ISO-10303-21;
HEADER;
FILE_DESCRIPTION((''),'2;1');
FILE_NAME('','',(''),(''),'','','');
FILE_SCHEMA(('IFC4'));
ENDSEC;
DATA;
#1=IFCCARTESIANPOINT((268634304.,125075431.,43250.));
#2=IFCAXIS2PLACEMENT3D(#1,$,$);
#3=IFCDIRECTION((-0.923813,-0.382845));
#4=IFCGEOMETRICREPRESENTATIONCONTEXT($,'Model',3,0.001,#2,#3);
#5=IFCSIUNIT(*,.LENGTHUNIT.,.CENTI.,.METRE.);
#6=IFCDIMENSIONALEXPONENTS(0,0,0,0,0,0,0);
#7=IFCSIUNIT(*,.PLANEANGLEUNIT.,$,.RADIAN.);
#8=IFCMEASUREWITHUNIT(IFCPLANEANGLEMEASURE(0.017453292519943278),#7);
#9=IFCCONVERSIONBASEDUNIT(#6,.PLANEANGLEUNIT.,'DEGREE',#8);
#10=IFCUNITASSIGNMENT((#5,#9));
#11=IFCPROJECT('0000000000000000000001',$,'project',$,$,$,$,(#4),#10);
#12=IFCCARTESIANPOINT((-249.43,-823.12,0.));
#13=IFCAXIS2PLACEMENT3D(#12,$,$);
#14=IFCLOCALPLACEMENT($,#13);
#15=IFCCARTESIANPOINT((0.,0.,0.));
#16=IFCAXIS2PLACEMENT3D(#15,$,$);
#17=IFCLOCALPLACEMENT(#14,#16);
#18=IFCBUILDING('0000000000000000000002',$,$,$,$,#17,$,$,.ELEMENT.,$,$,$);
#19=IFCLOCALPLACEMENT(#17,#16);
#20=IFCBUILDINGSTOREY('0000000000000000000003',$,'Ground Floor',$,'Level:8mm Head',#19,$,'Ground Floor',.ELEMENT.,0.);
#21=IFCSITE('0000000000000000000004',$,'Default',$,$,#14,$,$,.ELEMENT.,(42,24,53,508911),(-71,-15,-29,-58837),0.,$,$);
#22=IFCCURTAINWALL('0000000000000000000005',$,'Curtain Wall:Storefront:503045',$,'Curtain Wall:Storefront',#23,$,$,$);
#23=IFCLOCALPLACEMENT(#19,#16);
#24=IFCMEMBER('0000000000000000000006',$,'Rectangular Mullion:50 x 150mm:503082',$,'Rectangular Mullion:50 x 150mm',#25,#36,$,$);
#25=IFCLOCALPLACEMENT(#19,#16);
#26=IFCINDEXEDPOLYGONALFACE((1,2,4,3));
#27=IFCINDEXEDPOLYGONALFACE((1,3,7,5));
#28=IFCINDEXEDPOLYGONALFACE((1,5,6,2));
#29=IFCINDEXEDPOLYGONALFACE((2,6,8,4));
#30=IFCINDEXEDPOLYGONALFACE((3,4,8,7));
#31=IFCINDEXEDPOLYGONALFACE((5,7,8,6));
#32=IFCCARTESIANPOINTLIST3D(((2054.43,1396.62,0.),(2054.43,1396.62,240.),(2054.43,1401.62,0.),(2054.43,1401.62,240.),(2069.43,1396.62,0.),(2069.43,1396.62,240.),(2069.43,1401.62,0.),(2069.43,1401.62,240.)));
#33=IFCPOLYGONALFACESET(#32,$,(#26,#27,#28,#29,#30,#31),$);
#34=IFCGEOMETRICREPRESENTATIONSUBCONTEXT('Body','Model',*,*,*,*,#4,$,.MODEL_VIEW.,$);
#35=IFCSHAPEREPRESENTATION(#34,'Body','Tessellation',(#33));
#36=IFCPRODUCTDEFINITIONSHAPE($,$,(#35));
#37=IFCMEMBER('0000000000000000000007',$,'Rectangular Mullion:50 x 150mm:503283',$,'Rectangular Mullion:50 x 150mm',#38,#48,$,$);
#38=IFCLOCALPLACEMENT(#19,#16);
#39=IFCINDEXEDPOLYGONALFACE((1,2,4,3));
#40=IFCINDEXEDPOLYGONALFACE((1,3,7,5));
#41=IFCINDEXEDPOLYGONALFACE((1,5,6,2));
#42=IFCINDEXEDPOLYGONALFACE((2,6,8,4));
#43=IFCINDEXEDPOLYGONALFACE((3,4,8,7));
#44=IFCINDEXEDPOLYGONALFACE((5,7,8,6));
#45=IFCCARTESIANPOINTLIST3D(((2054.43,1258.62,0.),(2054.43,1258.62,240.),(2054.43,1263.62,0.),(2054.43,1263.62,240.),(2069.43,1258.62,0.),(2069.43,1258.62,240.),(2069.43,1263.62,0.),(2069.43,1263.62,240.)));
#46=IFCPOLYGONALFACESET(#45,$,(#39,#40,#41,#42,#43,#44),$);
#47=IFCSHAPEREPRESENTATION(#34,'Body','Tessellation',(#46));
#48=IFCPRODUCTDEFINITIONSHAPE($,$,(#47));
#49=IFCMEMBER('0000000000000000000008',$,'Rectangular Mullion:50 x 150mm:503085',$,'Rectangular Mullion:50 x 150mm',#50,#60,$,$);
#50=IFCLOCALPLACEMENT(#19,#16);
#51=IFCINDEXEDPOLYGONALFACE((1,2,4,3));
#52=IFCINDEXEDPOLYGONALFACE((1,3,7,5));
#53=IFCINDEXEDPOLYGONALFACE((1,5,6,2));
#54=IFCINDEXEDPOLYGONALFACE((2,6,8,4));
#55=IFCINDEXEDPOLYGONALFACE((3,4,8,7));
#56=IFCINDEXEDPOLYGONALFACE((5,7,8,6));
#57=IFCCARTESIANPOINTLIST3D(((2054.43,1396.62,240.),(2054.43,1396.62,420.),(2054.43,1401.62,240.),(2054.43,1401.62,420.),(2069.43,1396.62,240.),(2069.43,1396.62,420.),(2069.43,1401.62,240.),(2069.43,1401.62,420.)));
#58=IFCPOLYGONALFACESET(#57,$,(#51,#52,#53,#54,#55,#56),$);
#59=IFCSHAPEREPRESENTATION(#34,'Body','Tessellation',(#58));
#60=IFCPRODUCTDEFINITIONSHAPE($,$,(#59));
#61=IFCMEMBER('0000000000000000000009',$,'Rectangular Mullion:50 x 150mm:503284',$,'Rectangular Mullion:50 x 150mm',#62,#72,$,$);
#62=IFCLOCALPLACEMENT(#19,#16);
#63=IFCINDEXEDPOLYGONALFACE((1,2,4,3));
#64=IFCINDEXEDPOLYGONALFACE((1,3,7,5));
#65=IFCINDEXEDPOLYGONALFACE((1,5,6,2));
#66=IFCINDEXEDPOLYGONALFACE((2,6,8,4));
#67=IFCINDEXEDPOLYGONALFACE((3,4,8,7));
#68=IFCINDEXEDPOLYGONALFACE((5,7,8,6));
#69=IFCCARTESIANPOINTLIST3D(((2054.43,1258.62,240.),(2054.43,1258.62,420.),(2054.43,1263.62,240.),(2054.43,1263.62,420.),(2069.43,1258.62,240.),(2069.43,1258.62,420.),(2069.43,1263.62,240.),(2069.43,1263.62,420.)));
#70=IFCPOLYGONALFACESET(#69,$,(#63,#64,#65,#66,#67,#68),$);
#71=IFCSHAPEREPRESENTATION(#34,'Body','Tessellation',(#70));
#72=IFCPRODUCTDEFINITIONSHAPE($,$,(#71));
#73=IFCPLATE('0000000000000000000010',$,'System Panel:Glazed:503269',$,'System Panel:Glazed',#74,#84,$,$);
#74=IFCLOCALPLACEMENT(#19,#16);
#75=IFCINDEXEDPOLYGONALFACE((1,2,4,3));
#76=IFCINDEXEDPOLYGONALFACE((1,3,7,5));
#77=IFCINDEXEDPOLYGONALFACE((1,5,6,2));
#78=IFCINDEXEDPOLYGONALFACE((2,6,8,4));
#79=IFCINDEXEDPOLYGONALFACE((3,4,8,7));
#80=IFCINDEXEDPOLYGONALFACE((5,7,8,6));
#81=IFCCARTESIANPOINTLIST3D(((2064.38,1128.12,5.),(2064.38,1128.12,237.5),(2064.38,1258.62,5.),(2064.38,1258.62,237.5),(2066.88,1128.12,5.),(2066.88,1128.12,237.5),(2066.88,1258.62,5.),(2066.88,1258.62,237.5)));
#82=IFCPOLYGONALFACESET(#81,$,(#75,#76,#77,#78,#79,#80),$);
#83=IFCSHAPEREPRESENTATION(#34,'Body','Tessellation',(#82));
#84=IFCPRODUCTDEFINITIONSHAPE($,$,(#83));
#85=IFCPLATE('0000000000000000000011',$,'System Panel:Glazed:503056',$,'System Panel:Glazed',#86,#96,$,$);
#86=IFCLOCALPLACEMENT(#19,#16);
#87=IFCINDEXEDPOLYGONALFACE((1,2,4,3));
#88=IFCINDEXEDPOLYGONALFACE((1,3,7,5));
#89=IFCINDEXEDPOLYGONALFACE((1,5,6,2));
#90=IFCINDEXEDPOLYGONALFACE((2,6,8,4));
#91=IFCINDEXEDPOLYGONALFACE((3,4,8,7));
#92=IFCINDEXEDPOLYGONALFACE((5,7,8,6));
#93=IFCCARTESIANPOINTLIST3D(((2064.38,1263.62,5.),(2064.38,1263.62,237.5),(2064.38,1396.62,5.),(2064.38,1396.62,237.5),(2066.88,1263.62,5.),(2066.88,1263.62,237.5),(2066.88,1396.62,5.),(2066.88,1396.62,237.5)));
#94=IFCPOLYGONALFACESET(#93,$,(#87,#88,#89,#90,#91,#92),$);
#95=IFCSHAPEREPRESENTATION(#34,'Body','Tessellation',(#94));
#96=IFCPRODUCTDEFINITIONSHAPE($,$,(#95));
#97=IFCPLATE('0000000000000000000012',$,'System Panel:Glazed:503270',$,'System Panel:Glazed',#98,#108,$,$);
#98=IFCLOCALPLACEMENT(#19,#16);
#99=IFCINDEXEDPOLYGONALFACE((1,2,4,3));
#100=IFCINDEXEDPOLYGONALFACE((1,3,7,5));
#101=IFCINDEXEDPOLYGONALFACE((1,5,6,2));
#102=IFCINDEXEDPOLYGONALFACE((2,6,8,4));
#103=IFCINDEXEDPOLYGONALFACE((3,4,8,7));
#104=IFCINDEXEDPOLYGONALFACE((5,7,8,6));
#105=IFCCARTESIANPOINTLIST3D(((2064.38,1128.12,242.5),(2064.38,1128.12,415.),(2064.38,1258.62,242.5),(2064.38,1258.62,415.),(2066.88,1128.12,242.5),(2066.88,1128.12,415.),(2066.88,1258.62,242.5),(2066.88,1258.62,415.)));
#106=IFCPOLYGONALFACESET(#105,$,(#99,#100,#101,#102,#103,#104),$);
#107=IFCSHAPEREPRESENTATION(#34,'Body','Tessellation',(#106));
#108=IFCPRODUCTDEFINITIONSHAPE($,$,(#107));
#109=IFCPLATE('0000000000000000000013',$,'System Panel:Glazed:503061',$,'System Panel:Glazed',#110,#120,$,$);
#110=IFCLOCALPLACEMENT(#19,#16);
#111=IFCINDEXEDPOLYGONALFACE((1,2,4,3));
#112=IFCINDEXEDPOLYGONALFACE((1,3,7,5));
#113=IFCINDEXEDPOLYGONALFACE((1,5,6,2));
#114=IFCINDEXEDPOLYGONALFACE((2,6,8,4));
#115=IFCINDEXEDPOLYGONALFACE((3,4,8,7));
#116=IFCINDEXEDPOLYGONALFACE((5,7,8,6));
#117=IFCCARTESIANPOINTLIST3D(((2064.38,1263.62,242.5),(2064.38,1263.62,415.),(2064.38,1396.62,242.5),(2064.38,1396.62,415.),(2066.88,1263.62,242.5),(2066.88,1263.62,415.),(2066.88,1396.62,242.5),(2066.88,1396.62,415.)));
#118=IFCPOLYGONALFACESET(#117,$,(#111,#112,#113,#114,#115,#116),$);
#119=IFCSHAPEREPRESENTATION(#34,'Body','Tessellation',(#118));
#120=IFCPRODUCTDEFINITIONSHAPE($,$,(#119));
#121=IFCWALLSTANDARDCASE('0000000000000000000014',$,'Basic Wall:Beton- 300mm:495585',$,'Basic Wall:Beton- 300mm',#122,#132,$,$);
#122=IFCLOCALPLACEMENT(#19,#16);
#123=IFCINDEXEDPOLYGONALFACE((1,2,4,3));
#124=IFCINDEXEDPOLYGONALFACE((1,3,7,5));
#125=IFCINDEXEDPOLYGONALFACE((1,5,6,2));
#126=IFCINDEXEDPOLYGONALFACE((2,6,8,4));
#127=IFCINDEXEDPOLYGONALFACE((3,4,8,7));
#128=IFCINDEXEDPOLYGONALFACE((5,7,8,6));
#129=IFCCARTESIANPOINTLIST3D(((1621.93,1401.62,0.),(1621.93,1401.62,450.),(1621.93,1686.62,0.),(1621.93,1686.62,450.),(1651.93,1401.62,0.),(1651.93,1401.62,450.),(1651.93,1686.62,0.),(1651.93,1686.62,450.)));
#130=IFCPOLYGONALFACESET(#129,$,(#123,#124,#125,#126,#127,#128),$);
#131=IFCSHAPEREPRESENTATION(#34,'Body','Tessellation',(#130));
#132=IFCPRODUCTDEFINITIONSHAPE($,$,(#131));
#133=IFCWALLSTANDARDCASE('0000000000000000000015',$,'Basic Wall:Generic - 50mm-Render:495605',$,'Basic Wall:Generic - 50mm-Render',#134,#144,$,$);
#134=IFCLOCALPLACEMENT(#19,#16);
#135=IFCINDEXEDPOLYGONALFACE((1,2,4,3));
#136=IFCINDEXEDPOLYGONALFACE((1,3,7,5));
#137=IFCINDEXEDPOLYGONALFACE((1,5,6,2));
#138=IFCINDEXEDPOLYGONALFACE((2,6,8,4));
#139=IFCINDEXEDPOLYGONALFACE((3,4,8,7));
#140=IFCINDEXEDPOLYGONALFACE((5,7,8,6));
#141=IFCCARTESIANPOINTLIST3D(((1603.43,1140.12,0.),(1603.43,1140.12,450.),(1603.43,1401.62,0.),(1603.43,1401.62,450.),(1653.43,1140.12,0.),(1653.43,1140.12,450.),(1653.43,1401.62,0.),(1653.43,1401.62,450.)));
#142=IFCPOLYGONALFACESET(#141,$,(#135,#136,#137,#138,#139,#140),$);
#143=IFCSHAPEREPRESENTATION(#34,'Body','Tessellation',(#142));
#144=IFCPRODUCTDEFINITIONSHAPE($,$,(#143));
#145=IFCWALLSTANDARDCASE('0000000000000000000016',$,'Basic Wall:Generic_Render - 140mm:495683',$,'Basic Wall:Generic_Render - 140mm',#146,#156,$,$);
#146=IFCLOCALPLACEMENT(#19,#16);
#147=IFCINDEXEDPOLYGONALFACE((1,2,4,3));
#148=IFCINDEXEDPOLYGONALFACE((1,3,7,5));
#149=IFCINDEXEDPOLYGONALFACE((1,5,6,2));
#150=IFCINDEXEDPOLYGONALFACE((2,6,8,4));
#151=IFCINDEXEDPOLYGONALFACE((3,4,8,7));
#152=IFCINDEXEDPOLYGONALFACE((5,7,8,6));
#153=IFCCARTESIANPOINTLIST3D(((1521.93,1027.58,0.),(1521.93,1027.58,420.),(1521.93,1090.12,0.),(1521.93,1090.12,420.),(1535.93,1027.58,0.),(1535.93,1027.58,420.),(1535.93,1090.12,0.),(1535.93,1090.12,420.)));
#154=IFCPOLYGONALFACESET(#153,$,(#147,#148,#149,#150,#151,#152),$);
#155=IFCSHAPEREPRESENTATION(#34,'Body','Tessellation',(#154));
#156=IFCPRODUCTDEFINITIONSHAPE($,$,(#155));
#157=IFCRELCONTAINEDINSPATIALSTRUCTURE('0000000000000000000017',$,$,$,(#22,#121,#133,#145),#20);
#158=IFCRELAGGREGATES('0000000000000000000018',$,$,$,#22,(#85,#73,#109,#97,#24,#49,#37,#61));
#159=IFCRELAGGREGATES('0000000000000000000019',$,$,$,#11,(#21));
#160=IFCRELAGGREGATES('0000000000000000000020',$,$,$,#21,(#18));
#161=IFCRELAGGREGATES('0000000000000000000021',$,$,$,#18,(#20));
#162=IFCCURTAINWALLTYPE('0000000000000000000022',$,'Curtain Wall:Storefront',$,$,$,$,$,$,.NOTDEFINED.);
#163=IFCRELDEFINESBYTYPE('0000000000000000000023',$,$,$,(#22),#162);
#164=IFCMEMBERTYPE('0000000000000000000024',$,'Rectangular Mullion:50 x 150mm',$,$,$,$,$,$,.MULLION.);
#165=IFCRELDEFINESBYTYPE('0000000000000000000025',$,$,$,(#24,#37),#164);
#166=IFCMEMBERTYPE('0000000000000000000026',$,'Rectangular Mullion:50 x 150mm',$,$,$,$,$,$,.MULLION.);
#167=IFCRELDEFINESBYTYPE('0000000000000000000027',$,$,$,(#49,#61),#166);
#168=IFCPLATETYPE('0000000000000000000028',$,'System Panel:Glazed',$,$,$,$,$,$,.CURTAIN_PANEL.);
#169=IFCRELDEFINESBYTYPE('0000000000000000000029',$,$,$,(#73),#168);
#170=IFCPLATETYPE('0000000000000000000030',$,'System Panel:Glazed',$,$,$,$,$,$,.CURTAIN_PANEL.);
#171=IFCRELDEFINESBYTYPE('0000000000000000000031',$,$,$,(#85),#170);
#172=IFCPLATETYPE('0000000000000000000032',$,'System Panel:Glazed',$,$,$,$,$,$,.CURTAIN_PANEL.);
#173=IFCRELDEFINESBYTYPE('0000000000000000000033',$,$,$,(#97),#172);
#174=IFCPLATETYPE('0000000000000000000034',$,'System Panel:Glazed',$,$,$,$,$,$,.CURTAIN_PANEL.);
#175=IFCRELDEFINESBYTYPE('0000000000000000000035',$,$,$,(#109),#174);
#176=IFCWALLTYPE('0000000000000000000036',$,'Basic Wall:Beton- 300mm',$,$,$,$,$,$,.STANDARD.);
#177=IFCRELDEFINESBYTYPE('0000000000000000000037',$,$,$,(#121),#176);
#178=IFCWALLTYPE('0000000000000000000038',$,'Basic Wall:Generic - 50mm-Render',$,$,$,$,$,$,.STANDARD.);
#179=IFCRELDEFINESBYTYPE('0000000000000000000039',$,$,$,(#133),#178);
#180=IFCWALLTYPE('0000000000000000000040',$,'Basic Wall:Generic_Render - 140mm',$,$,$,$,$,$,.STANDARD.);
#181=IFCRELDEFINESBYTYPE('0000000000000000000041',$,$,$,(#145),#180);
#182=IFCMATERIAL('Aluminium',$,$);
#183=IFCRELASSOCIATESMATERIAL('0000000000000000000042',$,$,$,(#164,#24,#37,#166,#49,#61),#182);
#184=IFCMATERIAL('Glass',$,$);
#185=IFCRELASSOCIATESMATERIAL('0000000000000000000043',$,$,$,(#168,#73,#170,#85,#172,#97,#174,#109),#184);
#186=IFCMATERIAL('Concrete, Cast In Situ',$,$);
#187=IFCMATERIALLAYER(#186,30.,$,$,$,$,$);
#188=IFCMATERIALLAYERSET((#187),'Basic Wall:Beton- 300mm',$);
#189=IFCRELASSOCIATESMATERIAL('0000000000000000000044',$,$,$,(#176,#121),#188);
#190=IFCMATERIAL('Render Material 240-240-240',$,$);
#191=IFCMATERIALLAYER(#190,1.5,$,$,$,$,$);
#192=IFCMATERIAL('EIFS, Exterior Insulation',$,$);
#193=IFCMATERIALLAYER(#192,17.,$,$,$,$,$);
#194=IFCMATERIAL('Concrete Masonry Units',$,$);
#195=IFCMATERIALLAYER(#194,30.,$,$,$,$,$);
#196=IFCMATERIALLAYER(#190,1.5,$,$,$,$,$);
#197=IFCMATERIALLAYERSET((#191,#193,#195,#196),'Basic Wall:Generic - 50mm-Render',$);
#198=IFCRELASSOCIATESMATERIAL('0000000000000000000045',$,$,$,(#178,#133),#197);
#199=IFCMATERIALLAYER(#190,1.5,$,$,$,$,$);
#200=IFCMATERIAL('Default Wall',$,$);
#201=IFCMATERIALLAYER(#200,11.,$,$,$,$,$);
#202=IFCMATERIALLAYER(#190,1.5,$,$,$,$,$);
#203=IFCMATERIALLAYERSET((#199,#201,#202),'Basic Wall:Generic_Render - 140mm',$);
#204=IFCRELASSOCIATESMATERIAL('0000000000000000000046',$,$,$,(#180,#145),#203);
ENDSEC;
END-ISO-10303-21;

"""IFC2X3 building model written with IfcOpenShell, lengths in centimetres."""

from ifc_helpers import new_model, entity, si_unit, converted_unit, direction, frame, frame_2d, origin, origin_2d_with_axis, place, context, subcontext, project, spatial, rectangle, extrude, source, transform, mapped, material, layer, layer_set, layer_usage, type_object, type_shapes, element, aggregate, save


model = new_model("IFC2X3")

# Units and contexts
model_context = context("Model", 3, precision=0.001, world=frame((268634304.0, 125075431.0, 43250.0)), true_north=direction((-0.923813, -0.382845)))
body_context = subcontext(model_context, "Body", "Model", "MODEL_VIEW")
ifc_project = project(units=[si_unit("LENGTHUNIT", "METRE", prefix="CENTI"), converted_unit("PLANEANGLEUNIT", "DEGREE", entity("IfcPlaneAngleMeasure", 0.017453292519943278), si_unit("PLANEANGLEUNIT", "RADIAN"), dimensions=[0, 0, 0, 0, 0, 0, 0])], contexts=[model_context])

# Site, building, storey
site_placement = place(None, frame((-249.43, -823.12, 0.0)))
site = spatial("IfcSite", under=ifc_project, at=site_placement, Name="Default", CompositionType="ELEMENT", RefLatitude=(42, 24, 53, 508911), RefLongitude=(-71, -15, -29, -58837), RefElevation=0.0)
building_placement = place(site_placement, origin())
building = spatial("IfcBuilding", under=site, at=building_placement, CompositionType="ELEMENT")
storey_placement = place(building_placement, origin())
storey = spatial("IfcBuildingStorey", under=building, at=storey_placement, Name="Ground Floor", ObjectType="Level:8mm Head", LongName="Ground Floor", CompositionType="ELEMENT", Elevation=0.0)

# Curtain wall, members, plates
curtain_wall_type = type_object("IfcCurtainWallType", Name="Curtain Wall:Storefront", PredefinedType="NOTDEFINED")
curtain_wall_placement = place(storey_placement, origin())
curtain_wall = element("IfcCurtainWall", 1, at=curtain_wall_placement, inside=storey, type_object=curtain_wall_type, Name="Curtain Wall:Storefront:503045", ObjectType="Curtain Wall:Storefront")
ifc_material_1 = material(Name="Aluminium")
member_type_1 = type_object("IfcMemberType", Name="Rectangular Mullion:50 x 150mm", PredefinedType="MULLION", material=ifc_material_1)
shared_shape_1 = source(origin(), body_context, "Body", "SweptSolid", [
    extrude(rectangle(XDim=5.0, YDim=15.0, at=origin_2d_with_axis()), frame((0.0, 0.0, -240.0), z_axis=(0.0, 0.0, 1.0), x_axis=(-1.0, 0.0, 0.0)), (0.0, 0.0, 1.0), 240.0),
])
type_shapes(member_type_1, [shared_shape_1])
member_1_placement = place(curtain_wall_placement, frame((2061.93, 1399.12, 0.0), z_axis=(0.0, 0.0, -1.0), x_axis=(0.0, -1.0, 0.0)))
member_1 = element("IfcMember", 2, at=member_1_placement, type_object=member_type_1, material=ifc_material_1, Name="Rectangular Mullion:50 x 150mm:503082", ObjectType="Rectangular Mullion:50 x 150mm", context=body_context, shape_type="MappedRepresentation", body=[
    mapped(shared_shape_1, transform((0.0, 0.0, 0.0), scale=1.0)),
])
member_2_placement = place(curtain_wall_placement, frame((2061.93, 1261.12, 0.0), z_axis=(0.0, 0.0, -1.0), x_axis=(0.0, -1.0, 0.0)))
member_2 = element("IfcMember", 3, at=member_2_placement, type_object=member_type_1, material=ifc_material_1, Name="Rectangular Mullion:50 x 150mm:503283", ObjectType="Rectangular Mullion:50 x 150mm", context=body_context, shape_type="MappedRepresentation", body=[
    mapped(shared_shape_1, transform((0.0, 0.0, 0.0), scale=1.0)),
])
member_type_2 = type_object("IfcMemberType", Name="Rectangular Mullion:50 x 150mm", PredefinedType="MULLION", material=ifc_material_1)
shared_shape_2 = source(origin(), body_context, "Body", "SweptSolid", [
    extrude(rectangle(XDim=5.0, YDim=15.0, at=origin_2d_with_axis()), frame((0.0, 0.0, -180.0), z_axis=(0.0, 0.0, 1.0), x_axis=(-1.0, 0.0, 0.0)), (0.0, 0.0, 1.0), 180.0),
])
type_shapes(member_type_2, [shared_shape_2])
member_3_placement = place(curtain_wall_placement, frame((2061.93, 1399.12, 240.0), z_axis=(0.0, 0.0, -1.0), x_axis=(0.0, -1.0, 0.0)))
member_3 = element("IfcMember", 4, at=member_3_placement, type_object=member_type_2, material=ifc_material_1, Name="Rectangular Mullion:50 x 150mm:503085", ObjectType="Rectangular Mullion:50 x 150mm", context=body_context, shape_type="MappedRepresentation", body=[
    mapped(shared_shape_2, transform((0.0, 0.0, 0.0), scale=1.0)),
])
member_4_placement = place(curtain_wall_placement, frame((2061.93, 1261.12, 240.0), z_axis=(0.0, 0.0, -1.0), x_axis=(0.0, -1.0, 0.0)))
member_4 = element("IfcMember", 5, at=member_4_placement, type_object=member_type_2, material=ifc_material_1, Name="Rectangular Mullion:50 x 150mm:503284", ObjectType="Rectangular Mullion:50 x 150mm", context=body_context, shape_type="MappedRepresentation", body=[
    mapped(shared_shape_2, transform((0.0, 0.0, 0.0), scale=1.0)),
])
ifc_material_2 = material(Name="Glass")
plate_type_1 = type_object("IfcPlateType", Name="System Panel:Glazed", PredefinedType="CURTAIN_PANEL", material=ifc_material_2)
shared_shape_3 = source(origin(), body_context, "Body", "SweptSolid", [
    extrude(rectangle(XDim=2.5, YDim=130.5, at=origin_2d_with_axis()), frame((65.25, 1.25, 0.0), z_axis=(0.0, 0.0, 1.0), x_axis=(0.0, 1.0, 0.0)), (0.0, 0.0, 1.0), 232.5),
])
type_shapes(plate_type_1, [shared_shape_3])
plate_1_placement = place(curtain_wall_placement, frame((2064.38, 1258.62, 5.0), z_axis=(0.0, 0.0, 1.0), x_axis=(0.0, -1.0, 0.0)))
plate_1 = element("IfcPlate", 6, at=plate_1_placement, type_object=plate_type_1, material=ifc_material_2, Name="System Panel:Glazed:503269", ObjectType="System Panel:Glazed", context=body_context, shape_type="MappedRepresentation", body=[
    mapped(shared_shape_3, transform((0.0, 0.0, 0.0), scale=1.0)),
])
plate_type_2 = type_object("IfcPlateType", Name="System Panel:Glazed", PredefinedType="CURTAIN_PANEL", material=ifc_material_2)
shared_shape_4 = source(origin(), body_context, "Body", "SweptSolid", [
    extrude(rectangle(XDim=2.5, YDim=133.0, at=origin_2d_with_axis()), frame((66.5, 1.25, 0.0), z_axis=(0.0, 0.0, 1.0), x_axis=(0.0, 1.0, 0.0)), (0.0, 0.0, 1.0), 232.5),
])
type_shapes(plate_type_2, [shared_shape_4])
plate_2_placement = place(curtain_wall_placement, frame((2064.38, 1396.62, 5.0), z_axis=(0.0, 0.0, 1.0), x_axis=(0.0, -1.0, 0.0)))
plate_2 = element("IfcPlate", 7, at=plate_2_placement, type_object=plate_type_2, material=ifc_material_2, Name="System Panel:Glazed:503056", ObjectType="System Panel:Glazed", context=body_context, shape_type="MappedRepresentation", body=[
    mapped(shared_shape_4, transform((0.0, 0.0, 0.0), scale=1.0)),
])
plate_type_3 = type_object("IfcPlateType", Name="System Panel:Glazed", PredefinedType="CURTAIN_PANEL", material=ifc_material_2)
shared_shape_5 = source(origin(), body_context, "Body", "SweptSolid", [
    extrude(rectangle(XDim=2.5, YDim=130.5, at=origin_2d_with_axis()), frame((65.25, 1.25, 0.0), z_axis=(0.0, 0.0, 1.0), x_axis=(0.0, 1.0, 0.0)), (0.0, 0.0, 1.0), 172.5),
])
type_shapes(plate_type_3, [shared_shape_5])
plate_3_placement = place(curtain_wall_placement, frame((2064.38, 1258.62, 242.5), z_axis=(0.0, 0.0, 1.0), x_axis=(0.0, -1.0, 0.0)))
plate_3 = element("IfcPlate", 8, at=plate_3_placement, type_object=plate_type_3, material=ifc_material_2, Name="System Panel:Glazed:503270", ObjectType="System Panel:Glazed", context=body_context, shape_type="MappedRepresentation", body=[
    mapped(shared_shape_5, transform((0.0, 0.0, 0.0), scale=1.0)),
])
plate_type_4 = type_object("IfcPlateType", Name="System Panel:Glazed", PredefinedType="CURTAIN_PANEL", material=ifc_material_2)
shared_shape_6 = source(origin(), body_context, "Body", "SweptSolid", [
    extrude(rectangle(XDim=2.5, YDim=133.0, at=origin_2d_with_axis()), frame((66.5, 1.25, 0.0), z_axis=(0.0, 0.0, 1.0), x_axis=(0.0, 1.0, 0.0)), (0.0, 0.0, 1.0), 172.5),
])
type_shapes(plate_type_4, [shared_shape_6])
plate_4_placement = place(curtain_wall_placement, frame((2064.38, 1396.62, 242.5), z_axis=(0.0, 0.0, 1.0), x_axis=(0.0, -1.0, 0.0)))
plate_4 = element("IfcPlate", 9, at=plate_4_placement, type_object=plate_type_4, material=ifc_material_2, Name="System Panel:Glazed:503061", ObjectType="System Panel:Glazed", context=body_context, shape_type="MappedRepresentation", body=[
    mapped(shared_shape_6, transform((0.0, 0.0, 0.0), scale=1.0)),
])
aggregate(curtain_wall, [plate_2, plate_1, plate_4, plate_3, member_1, member_3, member_2, member_4])

# Walls
ifc_material_3 = material(Name="Concrete, Cast In Situ")
ifc_layer_1 = layer(ifc_material_3, 30.0)
ifc_layer_set_1 = layer_set([ifc_layer_1], Name="Basic Wall:Beton- 300mm")
ifc_layer_usage_1 = layer_usage(ifc_layer_set_1, "AXIS2", "NEGATIVE", 15.0)
wall_type_1 = type_object("IfcWallType", Name="Basic Wall:Beton- 300mm", PredefinedType="STANDARD", material=ifc_layer_set_1)
wall_1_placement = place(storey_placement, frame((1636.93, 1401.62, 0.0), z_axis=(0.0, 0.0, 1.0), x_axis=(0.0, 1.0, 0.0)))
element("IfcWallStandardCase", 10, at=wall_1_placement, inside=storey, type_object=wall_type_1, material=ifc_layer_usage_1, Name="Basic Wall:Beton- 300mm:495585", ObjectType="Basic Wall:Beton- 300mm", context=body_context, shape_type="SweptSolid", body=[
    extrude(rectangle(XDim=285.0, YDim=30.0, at=frame_2d((142.5, 0.0), x_axis=(-1.0, 0.0))), origin(), (0.0, 0.0, 1.0), 450.0),
])
ifc_material_4 = material(Name="Render Material 240-240-240")
ifc_layer_2 = layer(ifc_material_4, 1.5)
ifc_material_5 = material(Name="EIFS, Exterior Insulation")
ifc_layer_3 = layer(ifc_material_5, 17.0)
ifc_material_6 = material(Name="Concrete Masonry Units")
ifc_layer_4 = layer(ifc_material_6, 30.0)
ifc_layer_5 = layer(ifc_material_4, 1.5)
ifc_layer_set_2 = layer_set([ifc_layer_2, ifc_layer_3, ifc_layer_4, ifc_layer_5], Name="Basic Wall:Generic - 50mm-Render")
ifc_layer_usage_2 = layer_usage(ifc_layer_set_2, "AXIS2", "POSITIVE", -25.0)
wall_type_2 = type_object("IfcWallType", Name="Basic Wall:Generic - 50mm-Render", PredefinedType="STANDARD", material=ifc_layer_set_2)
wall_2_placement = place(storey_placement, frame((1628.43, 1401.62, 0.0), z_axis=(0.0, 0.0, 1.0), x_axis=(0.0, -1.0, 0.0)))
element("IfcWallStandardCase", 11, at=wall_2_placement, inside=storey, type_object=wall_type_2, material=ifc_layer_usage_2, Name="Basic Wall:Generic - 50mm-Render:495605", ObjectType="Basic Wall:Generic - 50mm-Render", context=body_context, shape_type="SweptSolid", body=[
    extrude(rectangle(XDim=261.5, YDim=50.0, at=frame_2d((130.75, 0.0), x_axis=(-1.0, 0.0))), origin(), (0.0, 0.0, 1.0), 450.0),
])
ifc_layer_6 = layer(ifc_material_4, 1.5)
ifc_material_7 = material(Name="Default Wall")
ifc_layer_7 = layer(ifc_material_7, 11.0)
ifc_layer_8 = layer(ifc_material_4, 1.5)
ifc_layer_set_3 = layer_set([ifc_layer_6, ifc_layer_7, ifc_layer_8], Name="Basic Wall:Generic_Render - 140mm")
ifc_layer_usage_3 = layer_usage(ifc_layer_set_3, "AXIS2", "POSITIVE", -7.0)
wall_type_3 = type_object("IfcWallType", Name="Basic Wall:Generic_Render - 140mm", PredefinedType="STANDARD", material=ifc_layer_set_3)
wall_3_placement = place(storey_placement, frame((1528.93, 1090.12, 0.0), z_axis=(0.0, 0.0, 1.0), x_axis=(0.0, -1.0, 0.0)))
element("IfcWallStandardCase", 12, at=wall_3_placement, inside=storey, type_object=wall_type_3, material=ifc_layer_usage_3, Name="Basic Wall:Generic_Render - 140mm:495683", ObjectType="Basic Wall:Generic_Render - 140mm", context=body_context, shape_type="SweptSolid", body=[
    extrude(rectangle(XDim=62.54, YDim=14.0, at=frame_2d((31.27, 0.0), x_axis=(-1.0, 0.0))), origin(), (0.0, 0.0, 1.0), 420.0),
])

save(model, "model.ifc")
